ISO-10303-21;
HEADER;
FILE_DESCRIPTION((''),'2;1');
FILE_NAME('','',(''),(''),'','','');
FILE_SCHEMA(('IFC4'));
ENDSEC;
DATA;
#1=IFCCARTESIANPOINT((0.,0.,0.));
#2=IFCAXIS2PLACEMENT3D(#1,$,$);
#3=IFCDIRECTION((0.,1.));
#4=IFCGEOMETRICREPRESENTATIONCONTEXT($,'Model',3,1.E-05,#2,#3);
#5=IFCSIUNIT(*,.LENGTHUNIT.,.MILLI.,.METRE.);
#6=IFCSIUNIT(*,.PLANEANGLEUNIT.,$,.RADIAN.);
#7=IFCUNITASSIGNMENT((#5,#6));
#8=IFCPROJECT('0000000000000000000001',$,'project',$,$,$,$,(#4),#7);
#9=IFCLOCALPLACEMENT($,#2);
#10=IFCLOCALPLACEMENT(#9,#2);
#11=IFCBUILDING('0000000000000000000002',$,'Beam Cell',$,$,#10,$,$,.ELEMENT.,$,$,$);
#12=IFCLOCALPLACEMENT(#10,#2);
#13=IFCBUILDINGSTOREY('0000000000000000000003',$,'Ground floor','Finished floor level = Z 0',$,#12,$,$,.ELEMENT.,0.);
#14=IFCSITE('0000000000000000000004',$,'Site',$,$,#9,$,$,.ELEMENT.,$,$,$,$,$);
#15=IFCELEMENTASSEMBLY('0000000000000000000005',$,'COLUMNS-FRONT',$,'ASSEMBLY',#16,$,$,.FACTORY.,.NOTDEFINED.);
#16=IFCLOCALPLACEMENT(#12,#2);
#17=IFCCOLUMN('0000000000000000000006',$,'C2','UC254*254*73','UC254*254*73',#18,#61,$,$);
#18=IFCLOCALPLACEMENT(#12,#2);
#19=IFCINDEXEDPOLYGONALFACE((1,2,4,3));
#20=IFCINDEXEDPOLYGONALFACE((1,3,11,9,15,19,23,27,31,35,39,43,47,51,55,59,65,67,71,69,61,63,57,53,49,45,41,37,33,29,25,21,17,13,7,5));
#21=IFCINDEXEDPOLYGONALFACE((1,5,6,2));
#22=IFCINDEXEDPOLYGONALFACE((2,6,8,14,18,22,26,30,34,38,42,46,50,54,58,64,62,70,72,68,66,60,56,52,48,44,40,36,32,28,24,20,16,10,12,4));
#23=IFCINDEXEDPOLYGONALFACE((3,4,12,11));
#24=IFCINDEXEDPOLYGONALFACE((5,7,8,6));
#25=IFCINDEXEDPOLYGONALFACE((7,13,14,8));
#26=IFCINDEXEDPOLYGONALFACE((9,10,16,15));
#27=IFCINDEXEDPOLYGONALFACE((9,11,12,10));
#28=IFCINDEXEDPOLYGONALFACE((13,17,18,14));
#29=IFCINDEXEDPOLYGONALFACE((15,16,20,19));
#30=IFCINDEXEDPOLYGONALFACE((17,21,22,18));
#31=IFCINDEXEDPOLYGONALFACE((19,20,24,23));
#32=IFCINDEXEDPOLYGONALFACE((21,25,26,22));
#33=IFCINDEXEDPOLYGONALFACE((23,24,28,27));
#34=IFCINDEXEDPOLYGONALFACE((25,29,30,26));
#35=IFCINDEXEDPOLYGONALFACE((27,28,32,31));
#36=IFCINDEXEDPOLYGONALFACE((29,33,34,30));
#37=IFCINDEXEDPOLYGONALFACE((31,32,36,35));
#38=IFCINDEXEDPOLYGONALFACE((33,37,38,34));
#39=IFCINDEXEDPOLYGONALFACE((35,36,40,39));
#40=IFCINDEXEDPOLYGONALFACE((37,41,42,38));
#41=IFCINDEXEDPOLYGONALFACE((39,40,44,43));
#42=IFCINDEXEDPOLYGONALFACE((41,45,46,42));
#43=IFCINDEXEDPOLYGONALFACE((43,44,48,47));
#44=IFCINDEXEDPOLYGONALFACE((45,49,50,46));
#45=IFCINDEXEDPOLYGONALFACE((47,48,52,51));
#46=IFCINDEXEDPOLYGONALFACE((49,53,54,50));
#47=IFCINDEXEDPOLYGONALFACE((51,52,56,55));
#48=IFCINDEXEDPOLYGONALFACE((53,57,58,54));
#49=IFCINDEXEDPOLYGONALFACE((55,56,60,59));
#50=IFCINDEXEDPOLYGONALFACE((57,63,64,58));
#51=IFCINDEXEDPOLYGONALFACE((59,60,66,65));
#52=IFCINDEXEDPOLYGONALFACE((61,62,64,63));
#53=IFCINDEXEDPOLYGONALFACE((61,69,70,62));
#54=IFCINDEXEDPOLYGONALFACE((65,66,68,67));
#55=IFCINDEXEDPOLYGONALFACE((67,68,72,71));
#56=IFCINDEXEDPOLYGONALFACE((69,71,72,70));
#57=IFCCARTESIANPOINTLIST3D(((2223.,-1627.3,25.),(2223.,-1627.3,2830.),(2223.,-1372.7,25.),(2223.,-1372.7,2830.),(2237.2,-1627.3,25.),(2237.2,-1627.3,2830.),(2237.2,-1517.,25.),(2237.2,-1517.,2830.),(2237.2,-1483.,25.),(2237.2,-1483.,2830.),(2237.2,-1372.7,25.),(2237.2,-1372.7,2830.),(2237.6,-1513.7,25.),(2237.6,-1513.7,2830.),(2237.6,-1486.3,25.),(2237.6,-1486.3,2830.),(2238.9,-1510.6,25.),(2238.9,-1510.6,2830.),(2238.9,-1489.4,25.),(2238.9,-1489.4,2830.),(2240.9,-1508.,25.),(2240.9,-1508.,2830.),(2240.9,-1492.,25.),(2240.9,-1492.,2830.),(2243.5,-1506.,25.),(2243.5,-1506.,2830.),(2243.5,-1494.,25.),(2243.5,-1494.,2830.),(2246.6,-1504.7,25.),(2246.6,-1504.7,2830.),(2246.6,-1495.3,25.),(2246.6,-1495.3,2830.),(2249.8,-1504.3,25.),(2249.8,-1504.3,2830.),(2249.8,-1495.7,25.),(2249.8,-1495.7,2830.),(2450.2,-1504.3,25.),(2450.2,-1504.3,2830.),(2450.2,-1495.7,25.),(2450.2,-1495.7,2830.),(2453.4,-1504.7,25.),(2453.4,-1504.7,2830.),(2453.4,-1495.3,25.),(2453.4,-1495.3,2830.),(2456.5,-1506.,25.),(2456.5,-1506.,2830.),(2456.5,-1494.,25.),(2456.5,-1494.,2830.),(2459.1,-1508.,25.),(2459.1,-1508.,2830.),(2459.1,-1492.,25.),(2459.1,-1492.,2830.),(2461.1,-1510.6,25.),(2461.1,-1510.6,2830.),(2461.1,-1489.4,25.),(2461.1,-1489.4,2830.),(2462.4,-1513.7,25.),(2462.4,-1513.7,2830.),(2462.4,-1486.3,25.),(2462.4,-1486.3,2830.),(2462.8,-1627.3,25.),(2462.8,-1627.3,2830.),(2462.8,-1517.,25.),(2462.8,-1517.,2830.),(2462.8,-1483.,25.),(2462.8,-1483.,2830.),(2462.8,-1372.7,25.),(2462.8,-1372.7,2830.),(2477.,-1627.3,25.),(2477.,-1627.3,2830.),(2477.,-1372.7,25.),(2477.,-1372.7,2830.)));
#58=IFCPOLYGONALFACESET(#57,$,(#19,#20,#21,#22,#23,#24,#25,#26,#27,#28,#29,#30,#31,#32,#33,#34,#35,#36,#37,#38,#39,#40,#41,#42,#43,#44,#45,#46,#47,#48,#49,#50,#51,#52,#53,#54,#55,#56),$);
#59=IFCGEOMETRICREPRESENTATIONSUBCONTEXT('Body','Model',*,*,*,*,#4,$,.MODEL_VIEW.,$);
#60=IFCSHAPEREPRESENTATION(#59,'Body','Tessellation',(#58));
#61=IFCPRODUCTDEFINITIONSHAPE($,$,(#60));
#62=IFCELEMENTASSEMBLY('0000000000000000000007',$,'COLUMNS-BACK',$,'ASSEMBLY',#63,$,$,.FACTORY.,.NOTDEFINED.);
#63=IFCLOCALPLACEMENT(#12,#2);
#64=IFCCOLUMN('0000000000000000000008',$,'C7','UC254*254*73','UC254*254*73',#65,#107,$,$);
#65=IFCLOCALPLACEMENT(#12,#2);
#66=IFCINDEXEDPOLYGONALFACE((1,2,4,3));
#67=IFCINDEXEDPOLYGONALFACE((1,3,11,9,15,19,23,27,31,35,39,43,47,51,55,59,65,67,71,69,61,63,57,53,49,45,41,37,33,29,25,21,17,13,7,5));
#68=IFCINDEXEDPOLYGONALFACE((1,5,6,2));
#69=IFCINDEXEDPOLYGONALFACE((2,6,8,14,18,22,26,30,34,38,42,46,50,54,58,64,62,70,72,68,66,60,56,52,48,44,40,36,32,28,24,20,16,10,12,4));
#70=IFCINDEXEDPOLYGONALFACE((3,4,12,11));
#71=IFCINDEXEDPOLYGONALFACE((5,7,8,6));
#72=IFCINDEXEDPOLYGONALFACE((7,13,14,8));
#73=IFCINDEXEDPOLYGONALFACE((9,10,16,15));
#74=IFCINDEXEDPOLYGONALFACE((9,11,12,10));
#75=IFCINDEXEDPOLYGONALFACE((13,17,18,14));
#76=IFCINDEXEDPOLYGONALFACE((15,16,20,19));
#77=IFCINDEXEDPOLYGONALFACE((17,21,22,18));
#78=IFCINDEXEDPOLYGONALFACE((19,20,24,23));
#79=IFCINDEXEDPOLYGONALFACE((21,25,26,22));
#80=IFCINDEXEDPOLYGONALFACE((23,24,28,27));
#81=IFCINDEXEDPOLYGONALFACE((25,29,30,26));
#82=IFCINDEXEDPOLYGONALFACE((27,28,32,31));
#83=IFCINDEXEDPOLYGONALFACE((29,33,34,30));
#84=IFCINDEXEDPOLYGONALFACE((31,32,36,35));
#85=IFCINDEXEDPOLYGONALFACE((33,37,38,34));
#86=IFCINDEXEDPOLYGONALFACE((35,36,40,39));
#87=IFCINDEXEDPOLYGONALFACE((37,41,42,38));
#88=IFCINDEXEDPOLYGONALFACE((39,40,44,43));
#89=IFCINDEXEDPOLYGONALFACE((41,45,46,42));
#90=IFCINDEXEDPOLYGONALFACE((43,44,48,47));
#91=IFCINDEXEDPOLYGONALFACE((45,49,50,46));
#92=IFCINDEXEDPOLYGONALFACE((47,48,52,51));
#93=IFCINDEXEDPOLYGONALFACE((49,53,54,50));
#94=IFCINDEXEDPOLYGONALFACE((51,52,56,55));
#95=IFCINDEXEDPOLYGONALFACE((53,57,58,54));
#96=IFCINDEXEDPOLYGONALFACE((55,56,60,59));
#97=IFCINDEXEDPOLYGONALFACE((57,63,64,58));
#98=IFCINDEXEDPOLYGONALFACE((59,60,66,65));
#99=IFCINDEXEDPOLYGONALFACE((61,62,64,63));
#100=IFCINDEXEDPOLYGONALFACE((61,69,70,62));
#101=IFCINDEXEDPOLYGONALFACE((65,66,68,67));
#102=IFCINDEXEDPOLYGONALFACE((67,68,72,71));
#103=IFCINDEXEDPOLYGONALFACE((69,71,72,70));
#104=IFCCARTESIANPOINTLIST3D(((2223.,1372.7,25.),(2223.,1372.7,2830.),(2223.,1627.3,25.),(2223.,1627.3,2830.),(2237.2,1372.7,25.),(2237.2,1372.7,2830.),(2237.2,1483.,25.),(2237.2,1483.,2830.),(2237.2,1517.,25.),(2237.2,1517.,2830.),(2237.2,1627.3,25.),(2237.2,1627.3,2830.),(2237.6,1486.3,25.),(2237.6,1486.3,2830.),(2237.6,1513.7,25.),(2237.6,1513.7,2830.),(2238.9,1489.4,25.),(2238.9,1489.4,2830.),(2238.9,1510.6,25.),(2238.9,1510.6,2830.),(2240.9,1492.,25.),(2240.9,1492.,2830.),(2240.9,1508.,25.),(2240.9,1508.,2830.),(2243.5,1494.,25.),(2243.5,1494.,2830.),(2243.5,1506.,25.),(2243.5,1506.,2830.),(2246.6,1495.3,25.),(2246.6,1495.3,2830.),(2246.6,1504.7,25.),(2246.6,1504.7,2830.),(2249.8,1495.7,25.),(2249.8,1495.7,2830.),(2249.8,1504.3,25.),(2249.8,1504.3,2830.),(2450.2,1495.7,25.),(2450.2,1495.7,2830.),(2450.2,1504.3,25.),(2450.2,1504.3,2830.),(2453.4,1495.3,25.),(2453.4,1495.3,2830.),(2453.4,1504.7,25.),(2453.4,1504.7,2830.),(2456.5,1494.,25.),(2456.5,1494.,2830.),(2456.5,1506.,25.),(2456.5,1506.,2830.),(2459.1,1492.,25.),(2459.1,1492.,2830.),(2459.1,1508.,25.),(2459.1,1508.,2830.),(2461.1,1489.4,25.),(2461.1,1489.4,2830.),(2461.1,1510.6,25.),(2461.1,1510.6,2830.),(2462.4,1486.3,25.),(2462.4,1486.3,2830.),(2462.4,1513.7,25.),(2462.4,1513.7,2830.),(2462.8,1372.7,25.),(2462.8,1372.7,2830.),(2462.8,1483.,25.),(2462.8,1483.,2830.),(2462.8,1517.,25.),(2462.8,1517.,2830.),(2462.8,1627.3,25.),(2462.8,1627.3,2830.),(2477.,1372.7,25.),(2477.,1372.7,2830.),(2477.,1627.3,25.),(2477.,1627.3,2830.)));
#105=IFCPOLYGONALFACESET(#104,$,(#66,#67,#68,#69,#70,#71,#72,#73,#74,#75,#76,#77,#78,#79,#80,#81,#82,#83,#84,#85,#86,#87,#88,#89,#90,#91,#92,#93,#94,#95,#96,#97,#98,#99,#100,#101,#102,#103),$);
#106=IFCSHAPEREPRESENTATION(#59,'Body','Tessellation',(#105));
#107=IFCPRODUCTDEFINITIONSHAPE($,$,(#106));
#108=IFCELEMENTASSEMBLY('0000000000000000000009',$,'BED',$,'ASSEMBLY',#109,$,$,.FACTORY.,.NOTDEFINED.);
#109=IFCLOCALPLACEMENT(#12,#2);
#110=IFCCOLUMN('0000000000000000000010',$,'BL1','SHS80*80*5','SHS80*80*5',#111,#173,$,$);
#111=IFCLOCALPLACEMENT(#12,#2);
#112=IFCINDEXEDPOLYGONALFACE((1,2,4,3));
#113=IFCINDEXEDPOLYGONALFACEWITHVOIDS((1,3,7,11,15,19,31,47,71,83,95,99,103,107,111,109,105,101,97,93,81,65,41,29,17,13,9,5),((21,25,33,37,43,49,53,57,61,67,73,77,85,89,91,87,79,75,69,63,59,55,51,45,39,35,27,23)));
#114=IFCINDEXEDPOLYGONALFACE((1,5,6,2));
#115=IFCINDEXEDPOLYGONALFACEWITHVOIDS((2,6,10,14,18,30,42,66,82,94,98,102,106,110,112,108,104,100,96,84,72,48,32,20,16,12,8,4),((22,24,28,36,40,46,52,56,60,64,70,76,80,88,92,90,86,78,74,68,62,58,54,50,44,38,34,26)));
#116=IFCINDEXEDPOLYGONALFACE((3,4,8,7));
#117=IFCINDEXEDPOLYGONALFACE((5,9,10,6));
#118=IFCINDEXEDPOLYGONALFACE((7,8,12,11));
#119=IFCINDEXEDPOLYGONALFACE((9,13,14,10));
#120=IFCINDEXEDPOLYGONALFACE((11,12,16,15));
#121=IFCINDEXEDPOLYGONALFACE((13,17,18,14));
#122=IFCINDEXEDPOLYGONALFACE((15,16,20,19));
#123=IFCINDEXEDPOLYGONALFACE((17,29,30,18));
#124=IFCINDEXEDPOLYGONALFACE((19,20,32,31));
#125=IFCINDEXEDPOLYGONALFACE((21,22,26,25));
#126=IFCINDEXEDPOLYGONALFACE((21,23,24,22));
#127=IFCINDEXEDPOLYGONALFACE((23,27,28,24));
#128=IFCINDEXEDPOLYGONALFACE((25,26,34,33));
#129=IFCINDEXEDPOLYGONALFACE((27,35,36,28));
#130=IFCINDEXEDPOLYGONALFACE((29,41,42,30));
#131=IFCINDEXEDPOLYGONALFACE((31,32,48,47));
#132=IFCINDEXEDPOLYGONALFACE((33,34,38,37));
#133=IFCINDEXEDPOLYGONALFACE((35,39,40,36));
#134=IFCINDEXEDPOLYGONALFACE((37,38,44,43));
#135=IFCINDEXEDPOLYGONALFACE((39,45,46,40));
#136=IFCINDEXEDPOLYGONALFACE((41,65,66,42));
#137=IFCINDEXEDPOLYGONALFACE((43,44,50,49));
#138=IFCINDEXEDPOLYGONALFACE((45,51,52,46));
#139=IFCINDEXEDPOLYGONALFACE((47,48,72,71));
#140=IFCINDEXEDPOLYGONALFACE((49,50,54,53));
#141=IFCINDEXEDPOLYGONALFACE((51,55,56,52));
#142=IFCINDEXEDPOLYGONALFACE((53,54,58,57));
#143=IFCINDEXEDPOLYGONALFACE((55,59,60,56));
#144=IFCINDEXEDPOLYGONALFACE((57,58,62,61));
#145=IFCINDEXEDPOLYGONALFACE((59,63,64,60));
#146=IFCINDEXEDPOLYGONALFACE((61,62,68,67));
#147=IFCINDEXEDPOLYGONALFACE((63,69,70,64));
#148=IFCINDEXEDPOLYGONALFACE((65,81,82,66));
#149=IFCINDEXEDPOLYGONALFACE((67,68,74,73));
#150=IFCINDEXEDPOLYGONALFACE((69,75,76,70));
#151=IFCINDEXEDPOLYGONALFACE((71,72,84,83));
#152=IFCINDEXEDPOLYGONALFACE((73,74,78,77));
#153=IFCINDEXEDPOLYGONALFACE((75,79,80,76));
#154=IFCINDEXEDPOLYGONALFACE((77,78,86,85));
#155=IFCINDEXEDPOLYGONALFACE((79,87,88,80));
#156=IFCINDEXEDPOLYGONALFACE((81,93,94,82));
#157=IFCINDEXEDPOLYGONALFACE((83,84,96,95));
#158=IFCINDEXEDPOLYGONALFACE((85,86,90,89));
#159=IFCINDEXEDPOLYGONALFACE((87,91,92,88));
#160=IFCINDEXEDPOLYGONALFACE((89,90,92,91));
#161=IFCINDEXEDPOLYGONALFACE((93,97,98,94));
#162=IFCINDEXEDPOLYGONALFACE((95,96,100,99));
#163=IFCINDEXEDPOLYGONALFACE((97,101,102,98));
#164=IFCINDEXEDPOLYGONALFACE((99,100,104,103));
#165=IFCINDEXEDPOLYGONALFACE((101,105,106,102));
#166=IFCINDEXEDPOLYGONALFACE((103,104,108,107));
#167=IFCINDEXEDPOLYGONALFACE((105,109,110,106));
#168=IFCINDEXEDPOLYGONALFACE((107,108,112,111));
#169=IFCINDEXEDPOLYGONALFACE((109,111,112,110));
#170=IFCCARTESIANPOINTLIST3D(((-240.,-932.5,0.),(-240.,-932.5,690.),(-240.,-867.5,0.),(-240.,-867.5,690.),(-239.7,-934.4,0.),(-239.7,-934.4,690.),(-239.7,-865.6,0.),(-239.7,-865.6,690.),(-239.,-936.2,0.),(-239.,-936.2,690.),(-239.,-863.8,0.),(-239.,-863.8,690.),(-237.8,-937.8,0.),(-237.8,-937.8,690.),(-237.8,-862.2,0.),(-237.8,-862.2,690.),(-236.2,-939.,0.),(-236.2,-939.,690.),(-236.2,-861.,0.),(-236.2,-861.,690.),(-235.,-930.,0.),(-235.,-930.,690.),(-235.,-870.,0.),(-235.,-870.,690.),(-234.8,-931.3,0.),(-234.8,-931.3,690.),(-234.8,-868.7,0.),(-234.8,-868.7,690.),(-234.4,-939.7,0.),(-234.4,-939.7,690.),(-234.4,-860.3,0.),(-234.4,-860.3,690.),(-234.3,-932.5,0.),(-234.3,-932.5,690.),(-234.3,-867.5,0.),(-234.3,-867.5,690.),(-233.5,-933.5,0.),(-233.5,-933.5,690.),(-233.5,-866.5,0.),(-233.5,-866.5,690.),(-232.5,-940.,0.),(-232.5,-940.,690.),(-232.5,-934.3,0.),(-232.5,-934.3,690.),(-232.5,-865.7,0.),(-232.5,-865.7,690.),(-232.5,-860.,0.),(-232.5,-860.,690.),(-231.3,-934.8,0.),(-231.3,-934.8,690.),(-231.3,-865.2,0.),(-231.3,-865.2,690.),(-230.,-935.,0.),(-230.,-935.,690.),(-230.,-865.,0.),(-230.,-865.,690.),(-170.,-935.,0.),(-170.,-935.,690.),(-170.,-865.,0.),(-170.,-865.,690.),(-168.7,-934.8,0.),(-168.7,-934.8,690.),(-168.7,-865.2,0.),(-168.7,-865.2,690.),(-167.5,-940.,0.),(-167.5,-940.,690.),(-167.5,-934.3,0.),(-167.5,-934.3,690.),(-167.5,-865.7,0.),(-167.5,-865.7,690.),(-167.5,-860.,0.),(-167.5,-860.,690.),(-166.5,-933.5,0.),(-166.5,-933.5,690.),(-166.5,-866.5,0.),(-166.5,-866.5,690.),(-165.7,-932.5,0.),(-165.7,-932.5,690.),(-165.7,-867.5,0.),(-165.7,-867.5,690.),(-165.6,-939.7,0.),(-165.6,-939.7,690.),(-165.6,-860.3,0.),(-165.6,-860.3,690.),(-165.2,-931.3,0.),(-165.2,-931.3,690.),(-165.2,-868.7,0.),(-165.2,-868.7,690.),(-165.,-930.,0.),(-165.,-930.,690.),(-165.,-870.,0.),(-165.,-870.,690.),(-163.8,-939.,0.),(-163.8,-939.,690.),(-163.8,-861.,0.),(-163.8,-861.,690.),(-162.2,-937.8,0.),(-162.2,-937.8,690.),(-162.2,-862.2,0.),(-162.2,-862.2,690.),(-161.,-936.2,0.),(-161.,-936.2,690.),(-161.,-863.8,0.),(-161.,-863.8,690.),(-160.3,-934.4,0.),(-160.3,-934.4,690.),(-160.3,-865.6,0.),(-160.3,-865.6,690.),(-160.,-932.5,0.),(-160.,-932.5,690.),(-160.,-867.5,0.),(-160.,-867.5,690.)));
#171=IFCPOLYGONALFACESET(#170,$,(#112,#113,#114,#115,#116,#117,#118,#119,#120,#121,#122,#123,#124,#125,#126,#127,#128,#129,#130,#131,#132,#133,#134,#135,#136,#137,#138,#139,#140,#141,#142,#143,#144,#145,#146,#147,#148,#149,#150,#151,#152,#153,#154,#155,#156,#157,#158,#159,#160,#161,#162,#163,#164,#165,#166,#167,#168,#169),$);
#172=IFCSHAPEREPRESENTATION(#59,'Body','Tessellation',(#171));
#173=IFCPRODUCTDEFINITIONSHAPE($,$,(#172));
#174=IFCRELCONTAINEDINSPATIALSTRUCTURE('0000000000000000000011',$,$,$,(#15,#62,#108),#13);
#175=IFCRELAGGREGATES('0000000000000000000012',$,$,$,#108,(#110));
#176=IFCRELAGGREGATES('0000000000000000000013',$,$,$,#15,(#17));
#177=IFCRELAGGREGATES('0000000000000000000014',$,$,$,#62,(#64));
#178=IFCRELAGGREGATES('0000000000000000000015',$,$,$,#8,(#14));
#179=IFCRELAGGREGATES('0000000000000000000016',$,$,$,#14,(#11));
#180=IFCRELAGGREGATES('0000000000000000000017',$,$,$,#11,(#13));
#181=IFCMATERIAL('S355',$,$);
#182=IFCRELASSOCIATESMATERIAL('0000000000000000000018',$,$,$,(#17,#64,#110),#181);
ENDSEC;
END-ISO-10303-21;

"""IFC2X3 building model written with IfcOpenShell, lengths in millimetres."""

from ifc_helpers import new_model, si_unit, direction, frame, origin, origin_2d, place, context, subcontext, project, spatial, hollow_rectangle, i_section, extrude, material, element, aggregate, save


model = new_model("IFC2X3")

# Units and contexts
model_context = context("Model", 3, precision=1e-05, world=origin(), true_north=direction((0.0, 1.0)))
body_context = subcontext(model_context, "Body", "Model", "MODEL_VIEW")
ifc_project = project(units=[si_unit("LENGTHUNIT", "METRE", prefix="MILLI"), si_unit("PLANEANGLEUNIT", "RADIAN")], contexts=[model_context])

# Site, building, storey
site_placement = place(None, origin())
site = spatial("IfcSite", under=ifc_project, at=site_placement, Name="Site", CompositionType="ELEMENT")
building_placement = place(site_placement, origin())
building = spatial("IfcBuilding", under=site, at=building_placement, Name="Beam Cell", CompositionType="ELEMENT")
storey_placement = place(building_placement, origin())
storey = spatial("IfcBuildingStorey", under=building, at=storey_placement, Name="Ground floor", Description="Finished floor level = Z 0", CompositionType="ELEMENT", Elevation=0.0)

# Element assemblies, columns
assembly_1_placement = place(storey_placement, origin())
assembly_1 = element("IfcElementAssembly", 1, at=assembly_1_placement, inside=storey, Name="COLUMNS-FRONT", ObjectType="ASSEMBLY", AssemblyPlace="FACTORY", PredefinedType="NOTDEFINED")
ifc_material = material(Name="S355")
column_1_placement = place(storey_placement, frame((2350.0, -1500.0, 25.0), z_axis=(0.0, 0.0, 1.0), x_axis=(0.0, 1.0, 0.0)))
column_1 = element("IfcColumn", 2, at=column_1_placement, material=ifc_material, Name="C2", Description="UC254*254*73", ObjectType="UC254*254*73", context=body_context, shape_type="SweptSolid", body=[
    extrude(i_section(OverallWidth=254.6, OverallDepth=254.1, WebThickness=8.6, FlangeThickness=14.2, FilletRadius=12.7, at=origin_2d()), origin(), (0.0, 0.0, 1.0), 2805.0),
])
assembly_2_placement = place(storey_placement, origin())
assembly_2 = element("IfcElementAssembly", 3, at=assembly_2_placement, inside=storey, Name="COLUMNS-BACK", ObjectType="ASSEMBLY", AssemblyPlace="FACTORY", PredefinedType="NOTDEFINED")
column_2_placement = place(storey_placement, frame((2350.0, 1500.0, 25.0), z_axis=(0.0, 0.0, 1.0), x_axis=(0.0, 1.0, 0.0)))
column_2 = element("IfcColumn", 4, at=column_2_placement, material=ifc_material, Name="C7", Description="UC254*254*73", ObjectType="UC254*254*73", context=body_context, shape_type="SweptSolid", body=[
    extrude(i_section(OverallWidth=254.6, OverallDepth=254.1, WebThickness=8.6, FlangeThickness=14.2, FilletRadius=12.7, at=origin_2d()), origin(), (0.0, 0.0, 1.0), 2805.0),
])

# Element assembly, column
assembly_3_placement = place(storey_placement, origin())
assembly_3 = element("IfcElementAssembly", 5, at=assembly_3_placement, inside=storey, Name="BED", ObjectType="ASSEMBLY", AssemblyPlace="FACTORY", PredefinedType="NOTDEFINED")
column_3_placement = place(storey_placement, frame((-200.0, -900.0, 0.0), z_axis=(0.0, 0.0, 1.0), x_axis=(1.0, 0.0, 0.0)))
column_3 = element("IfcColumn", 6, at=column_3_placement, material=ifc_material, Name="BL1", Description="SHS80*80*5", ObjectType="SHS80*80*5", context=body_context, shape_type="SweptSolid", body=[
    extrude(hollow_rectangle(XDim=80.0, YDim=80.0, WallThickness=5.0, InnerFilletRadius=5.0, OuterFilletRadius=7.5, at=origin_2d()), origin(), (0.0, 0.0, 1.0), 690.0),
])
aggregate(assembly_3, [column_3])

aggregate(assembly_1, [column_1])
aggregate(assembly_2, [column_2])

save(model, "model.ifc")
